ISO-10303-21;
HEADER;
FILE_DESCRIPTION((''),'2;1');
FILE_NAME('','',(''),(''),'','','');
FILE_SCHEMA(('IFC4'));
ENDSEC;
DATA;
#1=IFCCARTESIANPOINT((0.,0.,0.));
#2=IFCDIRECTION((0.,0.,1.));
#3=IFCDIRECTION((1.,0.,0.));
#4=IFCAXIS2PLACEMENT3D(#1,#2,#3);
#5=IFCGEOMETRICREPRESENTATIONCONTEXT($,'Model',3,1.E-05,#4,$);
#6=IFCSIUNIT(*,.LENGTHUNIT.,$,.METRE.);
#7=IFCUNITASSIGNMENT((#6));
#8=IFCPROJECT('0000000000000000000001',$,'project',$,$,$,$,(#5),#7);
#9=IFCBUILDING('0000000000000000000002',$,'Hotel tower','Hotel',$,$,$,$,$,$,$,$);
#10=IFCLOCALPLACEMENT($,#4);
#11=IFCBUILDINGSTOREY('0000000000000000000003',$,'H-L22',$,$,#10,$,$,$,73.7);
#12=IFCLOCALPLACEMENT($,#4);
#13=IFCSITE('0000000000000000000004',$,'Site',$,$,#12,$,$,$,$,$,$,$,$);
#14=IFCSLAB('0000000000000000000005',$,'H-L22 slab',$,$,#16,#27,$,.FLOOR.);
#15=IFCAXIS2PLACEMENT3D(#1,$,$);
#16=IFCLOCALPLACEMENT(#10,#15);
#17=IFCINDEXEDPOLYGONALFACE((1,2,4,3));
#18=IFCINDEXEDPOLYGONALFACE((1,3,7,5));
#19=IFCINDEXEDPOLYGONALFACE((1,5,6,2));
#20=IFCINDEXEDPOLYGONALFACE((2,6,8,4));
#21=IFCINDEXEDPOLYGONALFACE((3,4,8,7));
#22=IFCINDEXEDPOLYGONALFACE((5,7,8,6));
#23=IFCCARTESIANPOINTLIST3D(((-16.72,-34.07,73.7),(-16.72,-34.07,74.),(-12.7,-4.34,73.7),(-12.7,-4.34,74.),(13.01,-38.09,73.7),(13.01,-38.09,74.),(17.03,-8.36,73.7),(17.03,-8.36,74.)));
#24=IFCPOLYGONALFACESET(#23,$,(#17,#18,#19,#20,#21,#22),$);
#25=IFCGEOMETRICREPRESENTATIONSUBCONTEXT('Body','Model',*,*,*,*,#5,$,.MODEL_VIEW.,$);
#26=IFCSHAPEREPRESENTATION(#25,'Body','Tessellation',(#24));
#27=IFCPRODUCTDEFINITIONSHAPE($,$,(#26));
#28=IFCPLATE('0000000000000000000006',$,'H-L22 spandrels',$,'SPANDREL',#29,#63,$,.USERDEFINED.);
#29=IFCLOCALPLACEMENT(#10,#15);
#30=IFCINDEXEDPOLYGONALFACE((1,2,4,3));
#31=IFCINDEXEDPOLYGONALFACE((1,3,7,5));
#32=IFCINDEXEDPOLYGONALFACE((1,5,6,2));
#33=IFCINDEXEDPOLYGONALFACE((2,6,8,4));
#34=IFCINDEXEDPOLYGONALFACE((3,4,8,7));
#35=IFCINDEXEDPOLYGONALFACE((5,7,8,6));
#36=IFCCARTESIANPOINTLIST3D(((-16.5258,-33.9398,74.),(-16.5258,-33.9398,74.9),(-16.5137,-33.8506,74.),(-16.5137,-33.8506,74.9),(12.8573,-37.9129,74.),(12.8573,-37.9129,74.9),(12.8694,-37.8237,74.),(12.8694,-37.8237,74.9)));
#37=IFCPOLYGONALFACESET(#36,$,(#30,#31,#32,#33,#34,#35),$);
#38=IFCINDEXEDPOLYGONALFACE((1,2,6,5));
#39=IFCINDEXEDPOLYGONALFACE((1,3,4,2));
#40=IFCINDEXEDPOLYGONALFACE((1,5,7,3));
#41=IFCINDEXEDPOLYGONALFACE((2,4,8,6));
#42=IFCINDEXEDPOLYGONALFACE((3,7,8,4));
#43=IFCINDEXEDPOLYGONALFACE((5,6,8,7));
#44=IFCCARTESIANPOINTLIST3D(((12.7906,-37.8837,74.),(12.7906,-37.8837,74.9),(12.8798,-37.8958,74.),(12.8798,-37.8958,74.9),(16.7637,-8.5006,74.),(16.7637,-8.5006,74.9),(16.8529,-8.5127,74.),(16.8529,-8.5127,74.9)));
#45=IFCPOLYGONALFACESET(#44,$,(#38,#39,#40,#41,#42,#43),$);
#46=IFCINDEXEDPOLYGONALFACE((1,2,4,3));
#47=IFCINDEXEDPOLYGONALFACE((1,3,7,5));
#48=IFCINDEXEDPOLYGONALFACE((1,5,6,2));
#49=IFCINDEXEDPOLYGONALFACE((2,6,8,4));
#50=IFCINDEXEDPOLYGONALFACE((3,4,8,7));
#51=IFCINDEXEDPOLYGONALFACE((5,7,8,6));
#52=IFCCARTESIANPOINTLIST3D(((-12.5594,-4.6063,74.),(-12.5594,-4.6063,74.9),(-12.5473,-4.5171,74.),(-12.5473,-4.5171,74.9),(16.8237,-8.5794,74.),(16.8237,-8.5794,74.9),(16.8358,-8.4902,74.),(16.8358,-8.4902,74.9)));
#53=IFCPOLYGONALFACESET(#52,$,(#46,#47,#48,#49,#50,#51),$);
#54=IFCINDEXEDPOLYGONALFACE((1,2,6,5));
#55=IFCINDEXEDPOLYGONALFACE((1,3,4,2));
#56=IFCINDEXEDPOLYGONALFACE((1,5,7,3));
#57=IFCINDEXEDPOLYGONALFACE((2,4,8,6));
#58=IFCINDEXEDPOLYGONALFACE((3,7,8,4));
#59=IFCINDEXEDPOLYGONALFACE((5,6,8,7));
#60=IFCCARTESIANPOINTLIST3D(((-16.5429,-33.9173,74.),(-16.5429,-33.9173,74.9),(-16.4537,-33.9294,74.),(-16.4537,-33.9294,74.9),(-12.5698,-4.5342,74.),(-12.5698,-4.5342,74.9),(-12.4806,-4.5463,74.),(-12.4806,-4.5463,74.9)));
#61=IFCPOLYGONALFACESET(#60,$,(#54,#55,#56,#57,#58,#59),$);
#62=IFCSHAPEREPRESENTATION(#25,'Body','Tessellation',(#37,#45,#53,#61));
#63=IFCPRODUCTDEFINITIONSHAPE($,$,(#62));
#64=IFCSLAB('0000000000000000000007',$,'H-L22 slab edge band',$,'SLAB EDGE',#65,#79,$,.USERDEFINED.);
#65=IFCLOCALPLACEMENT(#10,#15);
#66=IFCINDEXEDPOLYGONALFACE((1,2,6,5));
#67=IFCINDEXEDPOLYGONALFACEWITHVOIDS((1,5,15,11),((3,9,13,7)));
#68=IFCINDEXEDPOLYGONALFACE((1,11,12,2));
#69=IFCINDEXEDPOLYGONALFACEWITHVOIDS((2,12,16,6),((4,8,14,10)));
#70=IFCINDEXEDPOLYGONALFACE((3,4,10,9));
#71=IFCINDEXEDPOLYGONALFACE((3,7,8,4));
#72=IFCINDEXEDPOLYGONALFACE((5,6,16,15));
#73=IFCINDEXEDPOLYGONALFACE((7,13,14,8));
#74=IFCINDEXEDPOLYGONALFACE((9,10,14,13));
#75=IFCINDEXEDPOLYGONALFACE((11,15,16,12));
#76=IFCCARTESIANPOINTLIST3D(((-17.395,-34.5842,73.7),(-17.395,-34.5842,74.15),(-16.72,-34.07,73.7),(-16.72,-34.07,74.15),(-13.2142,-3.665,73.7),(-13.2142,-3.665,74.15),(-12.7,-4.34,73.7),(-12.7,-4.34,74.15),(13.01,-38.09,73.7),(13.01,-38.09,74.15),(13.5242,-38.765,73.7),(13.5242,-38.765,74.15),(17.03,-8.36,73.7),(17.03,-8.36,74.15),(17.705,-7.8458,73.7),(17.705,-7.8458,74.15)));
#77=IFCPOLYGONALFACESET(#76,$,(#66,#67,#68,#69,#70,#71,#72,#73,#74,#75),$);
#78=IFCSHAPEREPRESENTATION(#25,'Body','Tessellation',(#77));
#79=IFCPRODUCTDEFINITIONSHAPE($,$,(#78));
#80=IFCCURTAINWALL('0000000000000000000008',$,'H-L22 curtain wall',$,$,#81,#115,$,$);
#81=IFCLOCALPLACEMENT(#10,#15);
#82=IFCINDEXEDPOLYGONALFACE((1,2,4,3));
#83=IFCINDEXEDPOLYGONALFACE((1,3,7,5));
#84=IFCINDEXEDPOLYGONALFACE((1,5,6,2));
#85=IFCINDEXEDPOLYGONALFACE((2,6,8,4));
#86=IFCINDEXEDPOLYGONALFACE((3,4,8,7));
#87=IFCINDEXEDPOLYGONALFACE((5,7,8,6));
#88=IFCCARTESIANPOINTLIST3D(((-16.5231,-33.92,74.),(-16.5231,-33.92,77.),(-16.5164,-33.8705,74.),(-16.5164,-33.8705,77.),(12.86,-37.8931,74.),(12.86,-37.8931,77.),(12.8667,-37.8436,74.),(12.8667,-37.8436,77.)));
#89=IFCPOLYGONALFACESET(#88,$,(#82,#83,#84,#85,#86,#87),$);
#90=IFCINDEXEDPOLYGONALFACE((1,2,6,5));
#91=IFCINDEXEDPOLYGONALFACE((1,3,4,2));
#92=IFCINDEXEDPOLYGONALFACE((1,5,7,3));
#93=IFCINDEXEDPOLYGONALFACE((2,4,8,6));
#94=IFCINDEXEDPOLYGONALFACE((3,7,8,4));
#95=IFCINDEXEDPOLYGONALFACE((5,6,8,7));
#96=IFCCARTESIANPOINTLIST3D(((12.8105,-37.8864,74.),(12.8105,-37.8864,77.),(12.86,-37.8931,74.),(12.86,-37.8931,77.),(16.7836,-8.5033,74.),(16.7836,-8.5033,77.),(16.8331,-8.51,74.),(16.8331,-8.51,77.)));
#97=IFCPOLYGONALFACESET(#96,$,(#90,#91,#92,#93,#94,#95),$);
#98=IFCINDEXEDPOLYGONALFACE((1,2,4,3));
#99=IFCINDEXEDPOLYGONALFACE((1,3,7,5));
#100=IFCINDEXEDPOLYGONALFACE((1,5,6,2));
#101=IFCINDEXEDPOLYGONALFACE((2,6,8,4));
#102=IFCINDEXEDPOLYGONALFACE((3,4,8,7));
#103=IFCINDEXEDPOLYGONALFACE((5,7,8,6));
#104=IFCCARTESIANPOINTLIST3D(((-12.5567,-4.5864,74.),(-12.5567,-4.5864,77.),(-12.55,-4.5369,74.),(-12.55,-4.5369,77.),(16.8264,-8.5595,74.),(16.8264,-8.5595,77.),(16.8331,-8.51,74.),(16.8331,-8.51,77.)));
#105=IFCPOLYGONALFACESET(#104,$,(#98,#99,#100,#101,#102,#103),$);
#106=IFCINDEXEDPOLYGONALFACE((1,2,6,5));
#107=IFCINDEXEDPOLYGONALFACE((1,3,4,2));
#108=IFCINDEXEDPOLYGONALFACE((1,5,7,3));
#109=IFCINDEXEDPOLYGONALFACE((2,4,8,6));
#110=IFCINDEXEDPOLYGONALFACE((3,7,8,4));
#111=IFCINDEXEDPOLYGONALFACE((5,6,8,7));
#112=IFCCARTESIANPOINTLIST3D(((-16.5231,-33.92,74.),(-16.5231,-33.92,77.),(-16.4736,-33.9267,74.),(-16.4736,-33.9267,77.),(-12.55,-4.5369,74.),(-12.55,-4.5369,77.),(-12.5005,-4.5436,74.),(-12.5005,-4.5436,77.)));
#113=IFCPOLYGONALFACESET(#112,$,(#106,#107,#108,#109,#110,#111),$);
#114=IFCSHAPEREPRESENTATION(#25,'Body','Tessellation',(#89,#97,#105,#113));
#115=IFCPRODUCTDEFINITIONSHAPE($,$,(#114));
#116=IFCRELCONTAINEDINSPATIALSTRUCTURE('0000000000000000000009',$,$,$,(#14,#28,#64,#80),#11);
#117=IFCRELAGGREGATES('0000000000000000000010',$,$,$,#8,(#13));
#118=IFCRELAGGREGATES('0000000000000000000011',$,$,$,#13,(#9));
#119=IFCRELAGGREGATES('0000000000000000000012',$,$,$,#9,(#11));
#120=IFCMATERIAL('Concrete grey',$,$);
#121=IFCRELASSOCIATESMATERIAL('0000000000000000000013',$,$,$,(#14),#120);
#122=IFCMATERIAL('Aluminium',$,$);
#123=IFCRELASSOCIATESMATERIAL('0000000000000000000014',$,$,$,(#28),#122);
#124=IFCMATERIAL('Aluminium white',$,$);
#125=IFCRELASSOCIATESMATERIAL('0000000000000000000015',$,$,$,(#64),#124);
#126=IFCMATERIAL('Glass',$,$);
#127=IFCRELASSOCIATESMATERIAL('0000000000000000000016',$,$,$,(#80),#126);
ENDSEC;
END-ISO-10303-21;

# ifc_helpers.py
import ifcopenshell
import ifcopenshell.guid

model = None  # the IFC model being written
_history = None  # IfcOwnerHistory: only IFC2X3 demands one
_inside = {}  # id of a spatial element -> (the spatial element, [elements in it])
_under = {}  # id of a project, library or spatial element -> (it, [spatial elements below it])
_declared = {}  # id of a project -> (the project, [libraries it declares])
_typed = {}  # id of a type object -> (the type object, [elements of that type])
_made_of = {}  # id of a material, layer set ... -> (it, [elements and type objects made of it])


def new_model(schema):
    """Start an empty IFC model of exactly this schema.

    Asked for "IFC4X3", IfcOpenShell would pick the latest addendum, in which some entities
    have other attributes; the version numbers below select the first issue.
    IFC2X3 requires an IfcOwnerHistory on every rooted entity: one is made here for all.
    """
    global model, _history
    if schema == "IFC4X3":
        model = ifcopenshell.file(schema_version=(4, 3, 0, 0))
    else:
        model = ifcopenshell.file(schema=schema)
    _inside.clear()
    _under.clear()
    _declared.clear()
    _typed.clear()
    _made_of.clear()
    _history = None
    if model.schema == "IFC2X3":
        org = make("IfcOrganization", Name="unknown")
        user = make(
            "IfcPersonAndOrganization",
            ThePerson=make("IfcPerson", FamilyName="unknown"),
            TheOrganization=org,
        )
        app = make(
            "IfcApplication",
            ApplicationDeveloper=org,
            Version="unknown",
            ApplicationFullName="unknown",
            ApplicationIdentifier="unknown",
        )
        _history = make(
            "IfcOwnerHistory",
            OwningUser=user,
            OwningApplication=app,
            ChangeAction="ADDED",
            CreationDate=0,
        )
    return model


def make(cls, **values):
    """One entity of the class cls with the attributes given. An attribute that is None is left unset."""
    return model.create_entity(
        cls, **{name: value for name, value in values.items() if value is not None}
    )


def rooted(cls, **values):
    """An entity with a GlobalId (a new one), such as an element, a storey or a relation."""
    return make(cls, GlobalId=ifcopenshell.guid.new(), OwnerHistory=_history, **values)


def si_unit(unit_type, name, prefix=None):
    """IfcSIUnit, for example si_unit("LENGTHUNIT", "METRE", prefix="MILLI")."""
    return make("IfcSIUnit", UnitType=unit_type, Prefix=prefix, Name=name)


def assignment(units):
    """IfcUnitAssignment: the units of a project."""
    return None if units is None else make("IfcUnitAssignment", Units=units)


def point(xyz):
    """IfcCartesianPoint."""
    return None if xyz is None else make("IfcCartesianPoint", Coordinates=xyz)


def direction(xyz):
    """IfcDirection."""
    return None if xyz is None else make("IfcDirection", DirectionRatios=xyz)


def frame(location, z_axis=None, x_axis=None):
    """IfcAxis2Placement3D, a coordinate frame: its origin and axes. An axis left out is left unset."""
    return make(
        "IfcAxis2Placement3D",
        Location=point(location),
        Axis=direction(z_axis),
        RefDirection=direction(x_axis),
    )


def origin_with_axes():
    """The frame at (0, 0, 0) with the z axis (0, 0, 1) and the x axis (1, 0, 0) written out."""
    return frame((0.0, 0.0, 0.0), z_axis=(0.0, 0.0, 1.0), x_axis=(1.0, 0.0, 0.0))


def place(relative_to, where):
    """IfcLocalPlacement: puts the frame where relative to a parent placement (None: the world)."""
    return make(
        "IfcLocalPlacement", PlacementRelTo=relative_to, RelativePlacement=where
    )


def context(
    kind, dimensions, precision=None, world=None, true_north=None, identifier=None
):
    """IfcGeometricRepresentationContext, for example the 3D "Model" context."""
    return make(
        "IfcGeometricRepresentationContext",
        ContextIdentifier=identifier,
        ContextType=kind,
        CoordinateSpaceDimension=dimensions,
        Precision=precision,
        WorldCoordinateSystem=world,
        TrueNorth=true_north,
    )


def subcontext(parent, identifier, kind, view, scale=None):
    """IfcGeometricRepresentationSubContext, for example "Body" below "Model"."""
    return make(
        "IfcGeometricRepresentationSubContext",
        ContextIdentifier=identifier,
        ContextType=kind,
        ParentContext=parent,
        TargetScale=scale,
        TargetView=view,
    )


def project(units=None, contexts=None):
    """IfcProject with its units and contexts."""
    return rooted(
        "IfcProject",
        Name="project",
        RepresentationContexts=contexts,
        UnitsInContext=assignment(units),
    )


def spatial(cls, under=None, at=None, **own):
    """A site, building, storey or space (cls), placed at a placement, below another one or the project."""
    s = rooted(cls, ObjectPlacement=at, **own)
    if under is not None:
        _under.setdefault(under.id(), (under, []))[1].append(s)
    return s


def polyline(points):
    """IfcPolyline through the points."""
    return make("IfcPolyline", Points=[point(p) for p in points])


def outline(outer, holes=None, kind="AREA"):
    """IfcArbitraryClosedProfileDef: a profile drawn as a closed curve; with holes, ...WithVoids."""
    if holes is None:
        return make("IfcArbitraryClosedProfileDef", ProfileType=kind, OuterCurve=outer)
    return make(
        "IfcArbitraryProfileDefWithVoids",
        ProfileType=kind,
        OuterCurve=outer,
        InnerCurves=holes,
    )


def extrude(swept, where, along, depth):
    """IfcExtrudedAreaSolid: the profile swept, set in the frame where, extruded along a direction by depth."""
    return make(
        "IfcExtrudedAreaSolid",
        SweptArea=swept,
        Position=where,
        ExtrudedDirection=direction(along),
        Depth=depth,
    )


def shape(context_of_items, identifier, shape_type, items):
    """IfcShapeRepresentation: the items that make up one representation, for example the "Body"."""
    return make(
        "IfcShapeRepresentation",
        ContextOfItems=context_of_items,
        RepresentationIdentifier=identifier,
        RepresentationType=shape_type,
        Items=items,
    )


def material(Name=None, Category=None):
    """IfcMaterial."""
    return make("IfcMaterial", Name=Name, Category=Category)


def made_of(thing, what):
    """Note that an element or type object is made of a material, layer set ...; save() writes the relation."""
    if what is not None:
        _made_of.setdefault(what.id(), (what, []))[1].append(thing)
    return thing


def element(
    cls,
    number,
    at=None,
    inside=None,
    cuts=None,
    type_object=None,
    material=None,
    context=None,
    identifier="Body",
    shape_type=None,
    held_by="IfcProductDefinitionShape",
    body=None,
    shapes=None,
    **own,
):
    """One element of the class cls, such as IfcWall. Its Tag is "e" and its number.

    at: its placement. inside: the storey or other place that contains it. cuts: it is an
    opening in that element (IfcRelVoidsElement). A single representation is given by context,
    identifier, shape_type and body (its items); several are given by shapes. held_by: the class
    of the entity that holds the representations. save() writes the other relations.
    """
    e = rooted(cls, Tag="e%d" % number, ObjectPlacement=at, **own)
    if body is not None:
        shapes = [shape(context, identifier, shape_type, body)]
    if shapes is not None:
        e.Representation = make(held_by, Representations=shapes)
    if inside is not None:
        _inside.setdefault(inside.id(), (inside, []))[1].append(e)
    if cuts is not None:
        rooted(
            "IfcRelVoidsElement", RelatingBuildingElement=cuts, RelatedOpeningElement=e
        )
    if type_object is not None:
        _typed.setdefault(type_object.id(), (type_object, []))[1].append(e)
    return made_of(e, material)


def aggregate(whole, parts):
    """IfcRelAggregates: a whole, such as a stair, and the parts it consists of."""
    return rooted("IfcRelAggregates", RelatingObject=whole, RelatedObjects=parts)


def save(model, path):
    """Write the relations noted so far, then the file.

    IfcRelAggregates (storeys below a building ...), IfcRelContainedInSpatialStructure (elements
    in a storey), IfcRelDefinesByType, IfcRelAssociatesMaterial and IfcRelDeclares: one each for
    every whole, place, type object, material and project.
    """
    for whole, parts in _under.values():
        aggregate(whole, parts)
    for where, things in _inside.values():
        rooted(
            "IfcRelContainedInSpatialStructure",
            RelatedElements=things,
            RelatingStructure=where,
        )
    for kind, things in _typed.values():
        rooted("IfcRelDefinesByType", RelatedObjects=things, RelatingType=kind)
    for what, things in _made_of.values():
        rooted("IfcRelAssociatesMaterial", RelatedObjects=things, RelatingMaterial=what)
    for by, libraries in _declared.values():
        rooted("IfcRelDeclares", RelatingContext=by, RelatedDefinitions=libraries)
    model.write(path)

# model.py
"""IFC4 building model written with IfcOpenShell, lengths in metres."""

from ifc_helpers import new_model, si_unit, frame, origin_with_axes, place, context, subcontext, project, spatial, polyline, outline, extrude, material, element, save


model = new_model("IFC4")

# Units and contexts
model_context = context("Model", 3, precision=1e-05, world=origin_with_axes())
body_context = subcontext(model_context, "Body", "Model", "MODEL_VIEW")
ifc_project = project(units=[si_unit("LENGTHUNIT", "METRE")], contexts=[model_context])

# Site, building, storey
site_placement = place(None, origin_with_axes())
site = spatial("IfcSite", under=ifc_project, at=site_placement, Name="Site")
building = spatial("IfcBuilding", under=site, Name="Hotel tower", Description="Hotel")
storey_placement = place(None, origin_with_axes())
storey = spatial("IfcBuildingStorey", under=building, at=storey_placement, Name="H-L22", Elevation=73.7)

# Shared definitions
ifc_material_1 = material(Name="Aluminium")

# Slab
ifc_material_2 = material(Name="Concrete grey")
slab_1_placement = place(storey_placement, origin_with_axes())
element("IfcSlab", 1, at=slab_1_placement, inside=storey, material=ifc_material_2, Name="H-L22 slab", PredefinedType="FLOOR", context=body_context, shape_type="SweptSolid", body=[
    extrude(outline(polyline([(-16.72, -34.07), (13.01, -38.09), (17.03, -8.36), (-12.7, -4.34), (-16.72, -34.07)])), frame((0.0, 0.0, 73.7), z_axis=(0.0, 0.0, 1.0), x_axis=(1.0, 0.0, 0.0)), (0.0, 0.0, 1.0), 0.3),
])

# Plate
plate_placement = place(storey_placement, origin_with_axes())
element("IfcPlate", 2, at=plate_placement, inside=storey, material=ifc_material_1, Name="H-L22 spandrels", ObjectType="SPANDREL", PredefinedType="USERDEFINED", context=body_context, shape_type="SweptSolid", body=[
    extrude(outline(polyline([(-16.5258, -33.9398), (12.8573, -37.9129), (12.8694, -37.8237), (-16.5137, -33.8506), (-16.5258, -33.9398)])), frame((0.0, 0.0, 74.0), z_axis=(0.0, 0.0, 1.0), x_axis=(1.0, 0.0, 0.0)), (0.0, 0.0, 1.0), 0.9),
    extrude(outline(polyline([(12.8798, -37.8958), (16.8529, -8.5127), (16.7637, -8.5006), (12.7906, -37.8837), (12.8798, -37.8958)])), frame((0.0, 0.0, 74.0), z_axis=(0.0, 0.0, 1.0), x_axis=(1.0, 0.0, 0.0)), (0.0, 0.0, 1.0), 0.9),
    extrude(outline(polyline([(16.8358, -8.4902), (-12.5473, -4.5171), (-12.5594, -4.6063), (16.8237, -8.5794), (16.8358, -8.4902)])), frame((0.0, 0.0, 74.0), z_axis=(0.0, 0.0, 1.0), x_axis=(1.0, 0.0, 0.0)), (0.0, 0.0, 1.0), 0.9),
    extrude(outline(polyline([(-12.5698, -4.5342), (-16.5429, -33.9173), (-16.4537, -33.9294), (-12.4806, -4.5463), (-12.5698, -4.5342)])), frame((0.0, 0.0, 74.0), z_axis=(0.0, 0.0, 1.0), x_axis=(1.0, 0.0, 0.0)), (0.0, 0.0, 1.0), 0.9),
])

# Slab
ifc_material_3 = material(Name="Aluminium white")
slab_2_placement = place(storey_placement, origin_with_axes())
element("IfcSlab", 3, at=slab_2_placement, inside=storey, material=ifc_material_3, Name="H-L22 slab edge band", ObjectType="SLAB EDGE", PredefinedType="USERDEFINED", context=body_context, shape_type="SweptSolid", body=[
    extrude(outline(polyline([(-17.395, -34.5842), (13.5242, -38.765), (17.705, -7.8458), (-13.2142, -3.665), (-17.395, -34.5842)]), holes=[polyline([(-16.72, -34.07), (13.01, -38.09), (17.03, -8.36), (-12.7, -4.34), (-16.72, -34.07)])]), frame((0.0, 0.0, 73.7), z_axis=(0.0, 0.0, 1.0), x_axis=(1.0, 0.0, 0.0)), (0.0, 0.0, 1.0), 0.45),
])

# Curtain wall
ifc_material_4 = material(Name="Glass")
curtain_wall_placement = place(storey_placement, origin_with_axes())
element("IfcCurtainWall", 4, at=curtain_wall_placement, inside=storey, material=ifc_material_4, Name="H-L22 curtain wall", context=body_context, shape_type="SweptSolid", body=[
    extrude(outline(polyline([(-16.5231, -33.92), (12.86, -37.8931), (12.8667, -37.8436), (-16.5164, -33.8705), (-16.5231, -33.92)])), frame((0.0, 0.0, 74.0), z_axis=(0.0, 0.0, 1.0), x_axis=(1.0, 0.0, 0.0)), (0.0, 0.0, 1.0), 3.0),
    extrude(outline(polyline([(12.86, -37.8931), (16.8331, -8.51), (16.7836, -8.5033), (12.8105, -37.8864), (12.86, -37.8931)])), frame((0.0, 0.0, 74.0), z_axis=(0.0, 0.0, 1.0), x_axis=(1.0, 0.0, 0.0)), (0.0, 0.0, 1.0), 3.0),
    extrude(outline(polyline([(16.8331, -8.51), (-12.55, -4.5369), (-12.5567, -4.5864), (16.8264, -8.5595), (16.8331, -8.51)])), frame((0.0, 0.0, 74.0), z_axis=(0.0, 0.0, 1.0), x_axis=(1.0, 0.0, 0.0)), (0.0, 0.0, 1.0), 3.0),
    extrude(outline(polyline([(-12.55, -4.5369), (-16.5231, -33.92), (-16.4736, -33.9267), (-12.5005, -4.5436), (-12.55, -4.5369)])), frame((0.0, 0.0, 74.0), z_axis=(0.0, 0.0, 1.0), x_axis=(1.0, 0.0, 0.0)), (0.0, 0.0, 1.0), 3.0),
])

save(model, "model.ifc")
